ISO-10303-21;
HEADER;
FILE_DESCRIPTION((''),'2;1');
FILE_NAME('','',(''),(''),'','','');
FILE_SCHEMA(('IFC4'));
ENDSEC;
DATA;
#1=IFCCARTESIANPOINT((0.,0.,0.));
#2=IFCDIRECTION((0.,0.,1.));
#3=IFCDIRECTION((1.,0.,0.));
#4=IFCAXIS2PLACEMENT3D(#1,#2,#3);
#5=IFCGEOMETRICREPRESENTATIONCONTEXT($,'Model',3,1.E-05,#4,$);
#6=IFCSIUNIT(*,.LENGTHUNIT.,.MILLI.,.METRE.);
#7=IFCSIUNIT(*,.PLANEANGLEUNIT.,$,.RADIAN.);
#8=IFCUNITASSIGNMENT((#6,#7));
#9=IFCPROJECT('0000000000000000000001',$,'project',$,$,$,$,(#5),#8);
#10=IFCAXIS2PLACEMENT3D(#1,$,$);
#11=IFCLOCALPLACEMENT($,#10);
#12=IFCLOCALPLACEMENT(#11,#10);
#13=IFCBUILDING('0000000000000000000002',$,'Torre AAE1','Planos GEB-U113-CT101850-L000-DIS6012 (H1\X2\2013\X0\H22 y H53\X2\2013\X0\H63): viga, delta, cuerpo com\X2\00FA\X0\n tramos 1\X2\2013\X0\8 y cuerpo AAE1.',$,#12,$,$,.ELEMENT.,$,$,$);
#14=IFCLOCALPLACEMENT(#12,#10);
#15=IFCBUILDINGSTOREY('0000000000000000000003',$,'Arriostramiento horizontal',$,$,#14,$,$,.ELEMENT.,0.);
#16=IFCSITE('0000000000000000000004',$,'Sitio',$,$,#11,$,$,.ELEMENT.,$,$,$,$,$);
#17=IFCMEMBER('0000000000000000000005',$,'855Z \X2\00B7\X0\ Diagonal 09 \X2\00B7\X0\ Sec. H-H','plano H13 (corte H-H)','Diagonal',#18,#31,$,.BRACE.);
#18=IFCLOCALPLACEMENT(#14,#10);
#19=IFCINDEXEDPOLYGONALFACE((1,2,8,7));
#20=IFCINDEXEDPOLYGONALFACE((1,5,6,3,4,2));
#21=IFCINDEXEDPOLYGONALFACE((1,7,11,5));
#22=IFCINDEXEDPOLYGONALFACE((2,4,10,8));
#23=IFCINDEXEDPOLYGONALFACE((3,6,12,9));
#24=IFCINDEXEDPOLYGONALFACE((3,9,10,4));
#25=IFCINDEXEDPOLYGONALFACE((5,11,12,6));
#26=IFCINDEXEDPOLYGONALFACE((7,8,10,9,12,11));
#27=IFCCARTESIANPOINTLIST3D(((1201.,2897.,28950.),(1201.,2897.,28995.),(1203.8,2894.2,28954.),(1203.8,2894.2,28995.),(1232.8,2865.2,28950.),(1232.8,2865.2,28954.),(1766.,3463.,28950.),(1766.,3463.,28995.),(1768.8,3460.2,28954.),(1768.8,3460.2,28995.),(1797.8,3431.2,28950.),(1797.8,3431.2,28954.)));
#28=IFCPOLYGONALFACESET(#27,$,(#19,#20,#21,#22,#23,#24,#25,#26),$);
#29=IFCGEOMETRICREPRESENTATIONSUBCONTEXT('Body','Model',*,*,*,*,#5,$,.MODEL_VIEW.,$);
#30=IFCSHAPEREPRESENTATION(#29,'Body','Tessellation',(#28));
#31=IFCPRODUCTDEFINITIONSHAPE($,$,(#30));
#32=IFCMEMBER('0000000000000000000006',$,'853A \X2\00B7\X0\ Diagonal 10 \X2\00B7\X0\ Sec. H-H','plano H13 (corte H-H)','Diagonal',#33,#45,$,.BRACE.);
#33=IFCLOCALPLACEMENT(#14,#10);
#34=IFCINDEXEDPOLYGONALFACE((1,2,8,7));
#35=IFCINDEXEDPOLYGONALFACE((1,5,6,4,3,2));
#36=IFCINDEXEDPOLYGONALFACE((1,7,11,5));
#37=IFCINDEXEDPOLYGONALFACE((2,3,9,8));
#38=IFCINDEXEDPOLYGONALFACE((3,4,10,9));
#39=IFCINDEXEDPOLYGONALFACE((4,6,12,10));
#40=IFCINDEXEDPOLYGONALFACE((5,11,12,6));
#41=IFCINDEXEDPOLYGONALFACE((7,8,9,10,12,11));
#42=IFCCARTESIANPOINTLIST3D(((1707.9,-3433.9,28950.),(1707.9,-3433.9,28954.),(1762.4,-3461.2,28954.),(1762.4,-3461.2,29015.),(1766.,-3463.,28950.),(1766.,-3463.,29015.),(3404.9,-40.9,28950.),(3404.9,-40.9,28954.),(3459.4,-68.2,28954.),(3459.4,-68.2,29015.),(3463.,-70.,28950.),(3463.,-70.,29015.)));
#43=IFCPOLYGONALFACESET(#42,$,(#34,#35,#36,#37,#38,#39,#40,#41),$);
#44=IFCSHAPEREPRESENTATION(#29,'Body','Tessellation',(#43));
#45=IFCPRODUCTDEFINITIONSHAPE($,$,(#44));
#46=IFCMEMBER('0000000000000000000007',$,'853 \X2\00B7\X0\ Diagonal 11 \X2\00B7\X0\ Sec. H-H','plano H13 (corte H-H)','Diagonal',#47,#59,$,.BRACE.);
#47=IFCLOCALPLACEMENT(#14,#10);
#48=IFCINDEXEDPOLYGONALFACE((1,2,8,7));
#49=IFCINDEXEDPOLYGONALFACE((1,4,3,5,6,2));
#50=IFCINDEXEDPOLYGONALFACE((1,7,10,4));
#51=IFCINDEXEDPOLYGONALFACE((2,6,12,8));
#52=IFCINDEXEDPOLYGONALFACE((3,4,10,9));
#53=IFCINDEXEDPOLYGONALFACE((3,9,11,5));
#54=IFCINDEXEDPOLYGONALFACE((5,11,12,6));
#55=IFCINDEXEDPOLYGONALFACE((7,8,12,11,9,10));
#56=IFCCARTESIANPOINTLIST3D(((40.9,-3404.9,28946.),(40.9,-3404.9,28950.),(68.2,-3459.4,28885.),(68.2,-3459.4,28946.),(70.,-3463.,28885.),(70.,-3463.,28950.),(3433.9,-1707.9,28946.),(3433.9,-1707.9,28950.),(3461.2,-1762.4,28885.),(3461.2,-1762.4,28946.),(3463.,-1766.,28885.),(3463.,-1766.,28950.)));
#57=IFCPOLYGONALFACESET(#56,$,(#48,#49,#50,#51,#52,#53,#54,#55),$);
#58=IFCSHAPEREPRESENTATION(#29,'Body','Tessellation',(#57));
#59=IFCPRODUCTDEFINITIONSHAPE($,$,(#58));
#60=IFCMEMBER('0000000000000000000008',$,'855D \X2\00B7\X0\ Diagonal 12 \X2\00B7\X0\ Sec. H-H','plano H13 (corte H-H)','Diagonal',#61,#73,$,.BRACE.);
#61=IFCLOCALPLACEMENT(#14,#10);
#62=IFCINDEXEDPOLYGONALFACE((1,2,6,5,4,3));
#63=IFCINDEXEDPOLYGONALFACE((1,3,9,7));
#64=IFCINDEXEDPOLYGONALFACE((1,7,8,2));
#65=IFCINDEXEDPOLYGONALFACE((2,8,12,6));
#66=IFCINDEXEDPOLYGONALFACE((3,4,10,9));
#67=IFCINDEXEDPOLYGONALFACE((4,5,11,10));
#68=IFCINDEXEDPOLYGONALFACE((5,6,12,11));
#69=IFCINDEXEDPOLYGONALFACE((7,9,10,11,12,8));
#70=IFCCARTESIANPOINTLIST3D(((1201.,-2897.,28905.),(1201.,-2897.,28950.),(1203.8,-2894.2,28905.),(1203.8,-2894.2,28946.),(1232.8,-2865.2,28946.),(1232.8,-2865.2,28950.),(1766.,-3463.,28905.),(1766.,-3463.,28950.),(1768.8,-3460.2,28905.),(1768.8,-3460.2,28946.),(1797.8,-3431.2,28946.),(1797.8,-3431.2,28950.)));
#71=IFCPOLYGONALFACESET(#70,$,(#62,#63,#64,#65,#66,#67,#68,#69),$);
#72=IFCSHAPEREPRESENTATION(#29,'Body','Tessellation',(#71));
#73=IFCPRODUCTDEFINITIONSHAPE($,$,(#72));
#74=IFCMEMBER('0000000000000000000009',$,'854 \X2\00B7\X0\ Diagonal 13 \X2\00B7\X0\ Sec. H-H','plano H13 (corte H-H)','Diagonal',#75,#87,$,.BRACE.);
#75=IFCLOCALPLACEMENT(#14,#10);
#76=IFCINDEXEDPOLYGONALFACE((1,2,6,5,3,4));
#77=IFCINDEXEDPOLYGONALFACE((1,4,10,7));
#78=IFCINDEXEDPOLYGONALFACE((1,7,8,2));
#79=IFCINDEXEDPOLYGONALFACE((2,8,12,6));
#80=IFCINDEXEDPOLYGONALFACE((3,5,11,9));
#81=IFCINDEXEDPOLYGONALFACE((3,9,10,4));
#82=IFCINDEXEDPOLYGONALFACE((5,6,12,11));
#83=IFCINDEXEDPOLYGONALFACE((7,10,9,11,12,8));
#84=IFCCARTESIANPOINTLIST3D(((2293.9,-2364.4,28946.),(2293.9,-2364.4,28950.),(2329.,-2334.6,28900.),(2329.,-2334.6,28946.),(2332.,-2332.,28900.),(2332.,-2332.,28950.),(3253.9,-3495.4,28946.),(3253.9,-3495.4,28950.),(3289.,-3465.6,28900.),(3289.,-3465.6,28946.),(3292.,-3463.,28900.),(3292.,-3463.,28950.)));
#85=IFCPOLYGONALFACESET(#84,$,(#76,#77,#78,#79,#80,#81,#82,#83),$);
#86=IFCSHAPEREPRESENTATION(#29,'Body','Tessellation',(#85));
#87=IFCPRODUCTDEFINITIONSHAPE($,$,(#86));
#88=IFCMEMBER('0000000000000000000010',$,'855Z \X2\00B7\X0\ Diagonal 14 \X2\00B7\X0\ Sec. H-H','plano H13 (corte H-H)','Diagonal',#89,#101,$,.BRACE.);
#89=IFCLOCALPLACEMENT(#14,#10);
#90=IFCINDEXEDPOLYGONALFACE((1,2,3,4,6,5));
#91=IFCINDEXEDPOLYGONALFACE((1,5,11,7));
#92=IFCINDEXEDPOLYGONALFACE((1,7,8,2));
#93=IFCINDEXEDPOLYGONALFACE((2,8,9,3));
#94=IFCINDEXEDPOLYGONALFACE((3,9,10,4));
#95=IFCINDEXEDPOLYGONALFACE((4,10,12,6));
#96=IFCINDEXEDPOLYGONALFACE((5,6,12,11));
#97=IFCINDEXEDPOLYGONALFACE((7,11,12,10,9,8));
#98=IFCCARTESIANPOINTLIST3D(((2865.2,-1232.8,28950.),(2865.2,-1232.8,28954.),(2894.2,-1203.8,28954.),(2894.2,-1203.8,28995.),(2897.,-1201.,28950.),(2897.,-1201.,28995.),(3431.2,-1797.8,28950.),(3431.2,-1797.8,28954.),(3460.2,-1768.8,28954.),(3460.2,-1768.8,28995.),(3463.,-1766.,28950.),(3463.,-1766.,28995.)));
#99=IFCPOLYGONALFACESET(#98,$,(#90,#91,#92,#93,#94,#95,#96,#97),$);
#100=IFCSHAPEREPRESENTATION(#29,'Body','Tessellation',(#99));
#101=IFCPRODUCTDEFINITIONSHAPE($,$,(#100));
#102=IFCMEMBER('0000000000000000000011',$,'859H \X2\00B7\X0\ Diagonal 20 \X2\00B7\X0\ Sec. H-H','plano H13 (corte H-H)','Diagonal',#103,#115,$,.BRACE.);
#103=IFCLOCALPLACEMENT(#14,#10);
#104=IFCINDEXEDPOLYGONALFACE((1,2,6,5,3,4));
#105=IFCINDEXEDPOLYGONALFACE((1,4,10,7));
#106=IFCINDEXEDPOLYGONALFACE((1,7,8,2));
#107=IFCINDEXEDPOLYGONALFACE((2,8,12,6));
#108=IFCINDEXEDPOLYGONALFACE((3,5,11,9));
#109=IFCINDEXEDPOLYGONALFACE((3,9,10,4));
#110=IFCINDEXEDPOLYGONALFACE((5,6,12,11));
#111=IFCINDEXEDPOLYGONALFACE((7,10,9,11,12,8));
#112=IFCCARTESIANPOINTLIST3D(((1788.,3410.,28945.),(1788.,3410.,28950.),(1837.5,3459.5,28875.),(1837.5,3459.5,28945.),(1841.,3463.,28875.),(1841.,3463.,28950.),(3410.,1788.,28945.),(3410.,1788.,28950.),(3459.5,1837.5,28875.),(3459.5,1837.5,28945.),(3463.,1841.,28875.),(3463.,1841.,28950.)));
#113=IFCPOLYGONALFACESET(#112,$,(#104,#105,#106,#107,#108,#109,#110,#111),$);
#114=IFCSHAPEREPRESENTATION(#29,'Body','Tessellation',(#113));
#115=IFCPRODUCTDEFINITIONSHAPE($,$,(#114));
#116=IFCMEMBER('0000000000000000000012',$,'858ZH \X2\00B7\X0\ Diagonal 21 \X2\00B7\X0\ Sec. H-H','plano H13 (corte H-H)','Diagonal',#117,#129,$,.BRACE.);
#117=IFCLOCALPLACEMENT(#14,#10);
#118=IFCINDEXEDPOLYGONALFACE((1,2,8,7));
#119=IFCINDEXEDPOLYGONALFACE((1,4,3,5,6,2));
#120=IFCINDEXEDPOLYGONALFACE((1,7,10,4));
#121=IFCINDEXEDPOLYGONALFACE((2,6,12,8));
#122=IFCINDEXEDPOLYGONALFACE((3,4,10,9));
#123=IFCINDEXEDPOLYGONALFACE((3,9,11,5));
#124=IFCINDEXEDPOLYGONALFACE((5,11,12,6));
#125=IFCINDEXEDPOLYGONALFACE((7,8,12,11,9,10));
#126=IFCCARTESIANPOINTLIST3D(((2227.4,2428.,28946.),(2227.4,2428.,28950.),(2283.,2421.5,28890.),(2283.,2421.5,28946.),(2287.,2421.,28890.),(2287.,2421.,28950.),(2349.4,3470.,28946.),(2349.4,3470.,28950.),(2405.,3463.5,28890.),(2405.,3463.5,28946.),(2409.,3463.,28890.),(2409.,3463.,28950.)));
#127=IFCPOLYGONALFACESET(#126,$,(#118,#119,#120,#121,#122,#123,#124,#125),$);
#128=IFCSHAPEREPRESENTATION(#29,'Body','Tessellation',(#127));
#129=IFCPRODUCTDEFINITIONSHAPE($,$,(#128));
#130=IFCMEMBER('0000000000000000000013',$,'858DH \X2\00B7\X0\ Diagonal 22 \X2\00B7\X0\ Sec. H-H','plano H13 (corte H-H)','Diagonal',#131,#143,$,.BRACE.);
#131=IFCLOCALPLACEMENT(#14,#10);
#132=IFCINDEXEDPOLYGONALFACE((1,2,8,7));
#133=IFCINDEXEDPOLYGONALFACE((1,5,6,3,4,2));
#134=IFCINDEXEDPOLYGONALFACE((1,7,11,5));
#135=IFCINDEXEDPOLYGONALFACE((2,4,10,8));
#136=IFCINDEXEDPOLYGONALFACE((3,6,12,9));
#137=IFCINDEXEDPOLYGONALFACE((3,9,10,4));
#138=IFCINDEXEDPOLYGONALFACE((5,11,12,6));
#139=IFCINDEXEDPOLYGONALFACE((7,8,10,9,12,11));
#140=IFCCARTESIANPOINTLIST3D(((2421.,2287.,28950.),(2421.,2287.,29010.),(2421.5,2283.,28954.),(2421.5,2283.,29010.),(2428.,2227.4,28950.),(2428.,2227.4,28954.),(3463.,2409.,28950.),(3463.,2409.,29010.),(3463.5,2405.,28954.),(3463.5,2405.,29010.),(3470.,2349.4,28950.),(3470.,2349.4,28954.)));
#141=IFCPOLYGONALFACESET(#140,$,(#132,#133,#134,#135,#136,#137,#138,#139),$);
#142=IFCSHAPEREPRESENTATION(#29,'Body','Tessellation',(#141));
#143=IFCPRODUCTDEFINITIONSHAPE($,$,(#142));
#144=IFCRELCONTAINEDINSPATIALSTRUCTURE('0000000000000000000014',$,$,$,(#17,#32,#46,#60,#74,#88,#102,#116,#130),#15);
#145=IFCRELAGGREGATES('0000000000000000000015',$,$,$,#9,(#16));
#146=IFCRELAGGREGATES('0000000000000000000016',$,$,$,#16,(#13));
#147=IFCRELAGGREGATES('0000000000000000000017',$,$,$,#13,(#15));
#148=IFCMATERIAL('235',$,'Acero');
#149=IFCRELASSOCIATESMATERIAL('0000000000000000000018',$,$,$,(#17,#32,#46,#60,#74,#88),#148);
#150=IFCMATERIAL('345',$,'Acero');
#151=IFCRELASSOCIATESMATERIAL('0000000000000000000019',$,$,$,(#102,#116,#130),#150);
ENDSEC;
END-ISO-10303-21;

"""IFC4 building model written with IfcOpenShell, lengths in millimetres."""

from ifc_helpers import new_model, si_unit, frame, frame_2d, origin, origin_with_axes, place, context, subcontext, project, spatial, l_section, extrude, material, element, save


model = new_model("IFC4")

# Units and contexts
model_context = context("Model", 3, precision=1e-05, world=origin_with_axes())
body_context = subcontext(model_context, "Body", "Model", "MODEL_VIEW")
ifc_project = project(units=[si_unit("LENGTHUNIT", "METRE", prefix="MILLI"), si_unit("PLANEANGLEUNIT", "RADIAN")], contexts=[model_context])

# Site, building, storey
site_placement = place(None, origin())
site = spatial("IfcSite", under=ifc_project, at=site_placement, Name="Sitio", CompositionType="ELEMENT")
building_placement = place(site_placement, origin())
building = spatial("IfcBuilding", under=site, at=building_placement, Name="Torre AAE1", Description="Planos GEB-U113-CT101850-L000-DIS6012 (H1–H22 y H53–H63): viga, delta, cuerpo común tramos 1–8 y cuerpo AAE1.", CompositionType="ELEMENT")
storey_placement = place(building_placement, origin())
storey = spatial("IfcBuildingStorey", under=building, at=storey_placement, Name="Arriostramiento horizontal", CompositionType="ELEMENT", Elevation=0.0)

# Members
ifc_material_1 = material(Name="235", Category="Acero")
member_1_placement = place(storey_placement, frame((1766.0, 3463.0, 28950.0), z_axis=(-0.706481, -0.707732, 0.0), x_axis=(0.707732, -0.706481, 0.0)))
element("IfcMember", 1, at=member_1_placement, inside=storey, material=ifc_material_1, Name="855Z · Diagonal 09 · Sec. H-H", Description="plano H13 (corte H-H)", ObjectType="Diagonal", PredefinedType="BRACE", context=body_context, shape_type="SweptSolid", body=[
    extrude(l_section(Depth=45.0, Width=45.0, Thickness=4.0, at=frame_2d((22.5, 22.5))), None, (0.0, 0.0, 1.0), 799.7),
])
for number, where, z_axis, x_axis, name in (
    (2, (1766.0, -3463.0, 28950.0), (0.447319, 0.894374, 0.0), (-0.894374, 0.447319, 0.0), "853A · Diagonal 10 · Sec. H-H"),
    (3, (3463.0, -1766.0, 28950.0), (-0.894374, -0.447319, 0.0), (-0.447319, 0.894374, 0.0), "853 · Diagonal 11 · Sec. H-H"),
):
    element("IfcMember", number, at=place(storey_placement, frame(where, z_axis=z_axis, x_axis=x_axis)), inside=storey, material=ifc_material_1, Name=name, Description="plano H13 (corte H-H)", ObjectType="Diagonal", PredefinedType="BRACE", context=body_context, shape_type="SweptSolid", body=[
        extrude(l_section(Depth=65.0, Width=65.0, Thickness=4.0, at=frame_2d((32.5, 32.5))), None, (0.0, 0.0, 1.0), 3793.7),
    ])
member_2_placement = place(storey_placement, frame((1766.0, -3463.0, 28950.0), z_axis=(-0.706481, 0.707732, 0.0), x_axis=(0.707732, 0.706481, 0.0)))
element("IfcMember", 4, at=member_2_placement, inside=storey, material=ifc_material_1, Name="855D · Diagonal 12 · Sec. H-H", Description="plano H13 (corte H-H)", ObjectType="Diagonal", PredefinedType="BRACE", context=body_context, shape_type="SweptSolid", body=[
    extrude(l_section(Depth=45.0, Width=45.0, Thickness=4.0, at=frame_2d((22.5, 22.5))), None, (0.0, 0.0, 1.0), 799.7),
])
member_3_placement = place(storey_placement, frame((2332.0, -2332.0, 28950.0), z_axis=(0.64712, -0.762388, 0.0), x_axis=(-0.762388, -0.64712, 0.0)))
element("IfcMember", 5, at=member_3_placement, inside=storey, material=ifc_material_1, Name="854 · Diagonal 13 · Sec. H-H", Description="plano H13 (corte H-H)", ObjectType="Diagonal", PredefinedType="BRACE", context=body_context, shape_type="SweptSolid", body=[
    extrude(l_section(Depth=50.0, Width=50.0, Thickness=4.0, at=frame_2d((25.0, 25.0))), None, (0.0, 0.0, 1.0), 1483.5),
])
member_4_placement = place(storey_placement, frame((3463.0, -1766.0, 28950.0), z_axis=(-0.707732, 0.706481, 0.0), x_axis=(-0.706481, -0.707732, 0.0)))
element("IfcMember", 6, at=member_4_placement, inside=storey, material=ifc_material_1, Name="855Z · Diagonal 14 · Sec. H-H", Description="plano H13 (corte H-H)", ObjectType="Diagonal", PredefinedType="BRACE", context=body_context, shape_type="SweptSolid", body=[
    extrude(l_section(Depth=45.0, Width=45.0, Thickness=4.0, at=frame_2d((22.5, 22.5))), None, (0.0, 0.0, 1.0), 799.7),
])
ifc_material_2 = material(Name="345", Category="Acero")
member_5_placement = place(storey_placement, frame((1841.0, 3463.0, 28950.0), z_axis=(0.707107, -0.707107, 0.0), x_axis=(-0.707107, -0.707107, 0.0)))
element("IfcMember", 7, at=member_5_placement, inside=storey, material=ifc_material_2, Name="859H · Diagonal 20 · Sec. H-H", Description="plano H13 (corte H-H)", ObjectType="Diagonal", PredefinedType="BRACE", context=body_context, shape_type="SweptSolid", body=[
    extrude(l_section(Depth=75.0, Width=75.0, Thickness=5.0, at=frame_2d((37.5, 37.5))), None, (0.0, 0.0, 1.0), 2293.9),
])
for number, where, z_axis, x_axis, name in (
    (8, (2409.0, 3463.0, 28950.0), (-0.116288, -0.993216, 0.0), (-0.993216, 0.116288, 0.0), "858ZH · Diagonal 21 · Sec. H-H"),
    (9, (3463.0, 2409.0, 28950.0), (-0.993216, -0.116288, 0.0), (0.116288, -0.993216, 0.0), "858DH · Diagonal 22 · Sec. H-H"),
):
    element("IfcMember", number, at=place(storey_placement, frame(where, z_axis=z_axis, x_axis=x_axis)), inside=storey, material=ifc_material_2, Name=name, Description="plano H13 (corte H-H)", ObjectType="Diagonal", PredefinedType="BRACE", context=body_context, shape_type="SweptSolid", body=[
        extrude(l_section(Depth=60.0, Width=60.0, Thickness=4.0, at=frame_2d((30.0, 30.0))), None, (0.0, 0.0, 1.0), 1049.1),
    ])

save(model, "model.ifc")
